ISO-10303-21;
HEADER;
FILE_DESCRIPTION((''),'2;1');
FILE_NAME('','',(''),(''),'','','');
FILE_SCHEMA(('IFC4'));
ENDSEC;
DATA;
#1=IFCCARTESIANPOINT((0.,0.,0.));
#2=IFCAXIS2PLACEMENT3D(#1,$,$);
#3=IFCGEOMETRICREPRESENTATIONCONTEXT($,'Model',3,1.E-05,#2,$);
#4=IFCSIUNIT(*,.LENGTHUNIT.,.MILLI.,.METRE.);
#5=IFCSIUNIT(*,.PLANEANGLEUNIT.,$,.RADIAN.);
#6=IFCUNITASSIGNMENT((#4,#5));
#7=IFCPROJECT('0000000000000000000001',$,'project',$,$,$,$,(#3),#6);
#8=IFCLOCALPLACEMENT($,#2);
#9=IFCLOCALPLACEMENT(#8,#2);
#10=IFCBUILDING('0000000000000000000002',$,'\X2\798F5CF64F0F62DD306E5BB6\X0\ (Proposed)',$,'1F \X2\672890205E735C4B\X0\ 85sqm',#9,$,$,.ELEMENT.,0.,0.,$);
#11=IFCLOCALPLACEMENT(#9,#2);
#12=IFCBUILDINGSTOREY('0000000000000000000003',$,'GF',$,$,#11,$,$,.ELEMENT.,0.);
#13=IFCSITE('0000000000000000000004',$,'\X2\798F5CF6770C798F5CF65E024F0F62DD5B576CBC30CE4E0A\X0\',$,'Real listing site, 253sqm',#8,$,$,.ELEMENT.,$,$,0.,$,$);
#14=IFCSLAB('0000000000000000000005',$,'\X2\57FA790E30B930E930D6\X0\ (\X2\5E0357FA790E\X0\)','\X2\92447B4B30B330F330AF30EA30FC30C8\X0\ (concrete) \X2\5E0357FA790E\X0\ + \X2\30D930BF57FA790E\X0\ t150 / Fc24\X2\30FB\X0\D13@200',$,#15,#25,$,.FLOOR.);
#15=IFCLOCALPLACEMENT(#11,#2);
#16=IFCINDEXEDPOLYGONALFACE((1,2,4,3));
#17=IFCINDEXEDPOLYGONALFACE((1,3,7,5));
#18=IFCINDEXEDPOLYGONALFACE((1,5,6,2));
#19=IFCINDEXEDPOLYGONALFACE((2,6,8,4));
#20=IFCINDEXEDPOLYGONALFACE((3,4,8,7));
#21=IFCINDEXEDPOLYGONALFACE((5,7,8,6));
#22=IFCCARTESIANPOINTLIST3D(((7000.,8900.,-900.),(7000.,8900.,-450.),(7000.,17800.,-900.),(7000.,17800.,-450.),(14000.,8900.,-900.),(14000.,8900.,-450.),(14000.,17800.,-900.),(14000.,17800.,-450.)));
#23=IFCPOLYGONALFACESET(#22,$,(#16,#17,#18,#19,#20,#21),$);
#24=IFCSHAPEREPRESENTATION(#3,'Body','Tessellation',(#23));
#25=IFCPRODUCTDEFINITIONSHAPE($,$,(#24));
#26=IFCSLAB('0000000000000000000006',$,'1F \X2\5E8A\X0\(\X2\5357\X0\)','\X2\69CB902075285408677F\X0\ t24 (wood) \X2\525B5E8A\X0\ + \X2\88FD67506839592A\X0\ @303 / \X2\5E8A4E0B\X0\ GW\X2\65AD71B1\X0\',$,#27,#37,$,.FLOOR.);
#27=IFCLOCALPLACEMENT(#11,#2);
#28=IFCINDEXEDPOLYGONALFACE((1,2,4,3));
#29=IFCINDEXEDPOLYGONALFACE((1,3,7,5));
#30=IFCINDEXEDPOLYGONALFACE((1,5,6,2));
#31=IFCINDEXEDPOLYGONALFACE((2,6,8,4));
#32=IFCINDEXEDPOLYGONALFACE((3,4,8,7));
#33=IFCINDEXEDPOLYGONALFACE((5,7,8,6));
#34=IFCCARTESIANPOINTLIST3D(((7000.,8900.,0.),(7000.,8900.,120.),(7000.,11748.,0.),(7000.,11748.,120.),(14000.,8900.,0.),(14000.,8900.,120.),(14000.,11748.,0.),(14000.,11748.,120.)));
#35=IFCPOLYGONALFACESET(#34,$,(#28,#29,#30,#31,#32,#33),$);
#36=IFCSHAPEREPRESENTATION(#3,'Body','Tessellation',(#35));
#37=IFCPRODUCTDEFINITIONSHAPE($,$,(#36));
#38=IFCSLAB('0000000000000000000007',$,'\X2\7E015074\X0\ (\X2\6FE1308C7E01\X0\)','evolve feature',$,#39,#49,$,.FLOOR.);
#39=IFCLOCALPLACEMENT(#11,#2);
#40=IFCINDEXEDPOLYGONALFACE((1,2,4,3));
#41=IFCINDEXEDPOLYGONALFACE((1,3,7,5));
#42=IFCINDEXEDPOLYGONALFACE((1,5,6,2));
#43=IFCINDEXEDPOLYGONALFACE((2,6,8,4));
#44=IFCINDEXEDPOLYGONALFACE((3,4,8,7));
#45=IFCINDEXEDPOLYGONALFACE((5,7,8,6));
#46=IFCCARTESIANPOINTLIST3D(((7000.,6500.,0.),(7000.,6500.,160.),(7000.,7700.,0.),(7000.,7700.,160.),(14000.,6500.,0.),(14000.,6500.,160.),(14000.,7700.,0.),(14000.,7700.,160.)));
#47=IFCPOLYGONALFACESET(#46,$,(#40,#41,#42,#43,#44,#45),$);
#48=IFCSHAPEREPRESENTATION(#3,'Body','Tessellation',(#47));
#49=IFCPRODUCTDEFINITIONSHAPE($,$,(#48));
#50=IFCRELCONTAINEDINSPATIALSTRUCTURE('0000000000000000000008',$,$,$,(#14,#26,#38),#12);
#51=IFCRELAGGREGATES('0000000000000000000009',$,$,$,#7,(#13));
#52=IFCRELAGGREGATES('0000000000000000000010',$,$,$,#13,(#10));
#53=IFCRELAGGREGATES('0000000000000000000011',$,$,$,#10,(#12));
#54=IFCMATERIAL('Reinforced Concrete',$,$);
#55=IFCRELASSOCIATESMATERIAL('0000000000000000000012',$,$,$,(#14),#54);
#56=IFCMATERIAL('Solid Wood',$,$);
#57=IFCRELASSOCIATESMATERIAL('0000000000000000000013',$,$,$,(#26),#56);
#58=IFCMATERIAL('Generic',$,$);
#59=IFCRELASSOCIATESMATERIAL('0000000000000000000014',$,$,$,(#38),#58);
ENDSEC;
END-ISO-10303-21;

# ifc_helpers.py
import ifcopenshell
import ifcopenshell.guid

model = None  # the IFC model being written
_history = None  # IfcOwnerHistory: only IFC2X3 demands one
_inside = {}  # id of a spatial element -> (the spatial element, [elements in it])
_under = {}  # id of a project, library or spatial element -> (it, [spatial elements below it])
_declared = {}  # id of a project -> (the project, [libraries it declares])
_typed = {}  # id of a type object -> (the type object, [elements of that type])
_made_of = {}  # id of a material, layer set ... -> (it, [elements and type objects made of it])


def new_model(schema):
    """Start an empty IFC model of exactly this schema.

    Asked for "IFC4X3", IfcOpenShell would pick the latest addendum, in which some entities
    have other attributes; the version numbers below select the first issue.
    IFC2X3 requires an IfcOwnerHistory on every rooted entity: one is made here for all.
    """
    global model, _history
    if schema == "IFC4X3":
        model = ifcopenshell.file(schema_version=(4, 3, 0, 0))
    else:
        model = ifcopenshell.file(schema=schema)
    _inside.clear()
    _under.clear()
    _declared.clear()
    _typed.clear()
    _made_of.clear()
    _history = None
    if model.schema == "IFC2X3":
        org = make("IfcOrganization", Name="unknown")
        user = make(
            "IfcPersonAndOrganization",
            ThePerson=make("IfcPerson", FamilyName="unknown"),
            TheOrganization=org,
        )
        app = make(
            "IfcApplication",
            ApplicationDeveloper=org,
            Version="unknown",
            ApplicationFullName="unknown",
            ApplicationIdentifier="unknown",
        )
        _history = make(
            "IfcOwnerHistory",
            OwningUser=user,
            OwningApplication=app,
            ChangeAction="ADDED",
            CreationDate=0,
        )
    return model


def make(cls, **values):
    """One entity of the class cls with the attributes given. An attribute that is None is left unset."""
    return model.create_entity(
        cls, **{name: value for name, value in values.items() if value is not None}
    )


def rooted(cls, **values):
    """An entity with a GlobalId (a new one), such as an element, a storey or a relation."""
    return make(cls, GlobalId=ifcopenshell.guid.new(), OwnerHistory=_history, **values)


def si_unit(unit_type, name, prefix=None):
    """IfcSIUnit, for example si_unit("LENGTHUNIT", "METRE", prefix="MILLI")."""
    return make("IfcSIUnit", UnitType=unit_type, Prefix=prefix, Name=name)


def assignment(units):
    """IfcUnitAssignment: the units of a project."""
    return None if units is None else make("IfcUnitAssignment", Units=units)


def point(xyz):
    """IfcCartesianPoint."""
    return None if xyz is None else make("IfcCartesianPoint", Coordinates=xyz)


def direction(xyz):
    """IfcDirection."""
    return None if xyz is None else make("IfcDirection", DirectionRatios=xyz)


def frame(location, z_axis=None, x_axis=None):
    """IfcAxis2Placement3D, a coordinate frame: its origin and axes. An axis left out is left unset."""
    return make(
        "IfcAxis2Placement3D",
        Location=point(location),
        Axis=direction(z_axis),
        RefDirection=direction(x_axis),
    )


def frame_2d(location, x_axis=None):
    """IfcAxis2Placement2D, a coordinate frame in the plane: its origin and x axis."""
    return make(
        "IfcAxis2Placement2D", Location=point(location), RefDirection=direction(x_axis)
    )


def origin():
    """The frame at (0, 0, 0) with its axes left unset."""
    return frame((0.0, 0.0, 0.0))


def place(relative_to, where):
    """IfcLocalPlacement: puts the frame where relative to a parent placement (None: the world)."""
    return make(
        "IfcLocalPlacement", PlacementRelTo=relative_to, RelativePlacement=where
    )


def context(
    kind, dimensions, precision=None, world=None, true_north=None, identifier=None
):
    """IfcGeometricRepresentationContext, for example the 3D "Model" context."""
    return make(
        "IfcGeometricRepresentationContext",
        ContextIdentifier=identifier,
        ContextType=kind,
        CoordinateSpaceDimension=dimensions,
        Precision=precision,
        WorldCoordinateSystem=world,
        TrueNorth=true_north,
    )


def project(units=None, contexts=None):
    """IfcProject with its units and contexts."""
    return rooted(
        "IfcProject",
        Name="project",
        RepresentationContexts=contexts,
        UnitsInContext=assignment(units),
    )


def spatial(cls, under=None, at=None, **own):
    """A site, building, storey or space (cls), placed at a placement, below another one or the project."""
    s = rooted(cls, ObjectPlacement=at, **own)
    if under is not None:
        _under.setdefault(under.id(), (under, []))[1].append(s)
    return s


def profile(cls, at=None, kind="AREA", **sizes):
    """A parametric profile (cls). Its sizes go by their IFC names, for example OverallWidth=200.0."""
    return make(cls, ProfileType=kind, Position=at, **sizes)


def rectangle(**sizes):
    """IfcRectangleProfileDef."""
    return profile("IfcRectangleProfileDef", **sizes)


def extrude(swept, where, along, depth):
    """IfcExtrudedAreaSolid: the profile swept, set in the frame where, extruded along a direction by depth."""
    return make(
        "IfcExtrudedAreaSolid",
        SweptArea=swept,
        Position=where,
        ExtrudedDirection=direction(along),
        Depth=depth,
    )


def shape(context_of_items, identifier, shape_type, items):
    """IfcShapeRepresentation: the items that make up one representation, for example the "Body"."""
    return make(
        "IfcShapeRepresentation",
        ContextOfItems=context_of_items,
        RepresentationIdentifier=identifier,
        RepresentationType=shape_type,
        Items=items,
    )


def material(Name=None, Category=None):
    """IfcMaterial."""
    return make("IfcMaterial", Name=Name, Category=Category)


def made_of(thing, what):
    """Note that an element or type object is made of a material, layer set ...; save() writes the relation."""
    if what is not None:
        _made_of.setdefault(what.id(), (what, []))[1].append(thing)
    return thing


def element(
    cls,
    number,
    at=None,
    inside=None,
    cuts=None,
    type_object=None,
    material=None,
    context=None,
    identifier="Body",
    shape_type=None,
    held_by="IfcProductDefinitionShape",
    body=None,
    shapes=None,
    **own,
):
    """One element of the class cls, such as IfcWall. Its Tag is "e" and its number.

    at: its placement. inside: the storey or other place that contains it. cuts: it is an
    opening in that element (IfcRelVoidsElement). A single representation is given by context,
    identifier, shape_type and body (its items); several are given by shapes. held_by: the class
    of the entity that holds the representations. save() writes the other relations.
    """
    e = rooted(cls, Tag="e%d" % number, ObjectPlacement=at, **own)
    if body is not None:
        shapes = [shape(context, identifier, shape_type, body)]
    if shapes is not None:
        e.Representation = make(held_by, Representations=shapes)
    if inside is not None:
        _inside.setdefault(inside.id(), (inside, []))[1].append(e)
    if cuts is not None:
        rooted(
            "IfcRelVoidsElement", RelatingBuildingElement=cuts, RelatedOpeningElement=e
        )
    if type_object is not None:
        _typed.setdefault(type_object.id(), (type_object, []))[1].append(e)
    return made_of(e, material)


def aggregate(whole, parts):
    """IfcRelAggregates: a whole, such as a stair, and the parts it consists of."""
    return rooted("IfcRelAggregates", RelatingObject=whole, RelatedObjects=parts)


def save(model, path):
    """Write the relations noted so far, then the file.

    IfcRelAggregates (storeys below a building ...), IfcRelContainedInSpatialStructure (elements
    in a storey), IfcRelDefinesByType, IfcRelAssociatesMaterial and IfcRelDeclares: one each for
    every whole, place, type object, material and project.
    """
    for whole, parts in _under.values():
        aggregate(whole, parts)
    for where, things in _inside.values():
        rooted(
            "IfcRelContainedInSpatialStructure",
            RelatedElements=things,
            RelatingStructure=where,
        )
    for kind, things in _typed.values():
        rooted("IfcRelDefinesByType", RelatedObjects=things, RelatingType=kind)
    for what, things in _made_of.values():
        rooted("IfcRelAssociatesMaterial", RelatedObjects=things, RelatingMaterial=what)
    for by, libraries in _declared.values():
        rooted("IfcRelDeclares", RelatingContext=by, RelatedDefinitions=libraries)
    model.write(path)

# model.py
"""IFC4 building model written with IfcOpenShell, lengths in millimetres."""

from ifc_helpers import new_model, si_unit, frame, frame_2d, origin, place, context, project, spatial, rectangle, extrude, material, element, save


model = new_model("IFC4")

# Units and contexts
model_context = context("Model", 3, precision=1e-05, world=origin())
ifc_project = project(units=[si_unit("LENGTHUNIT", "METRE", prefix="MILLI"), si_unit("PLANEANGLEUNIT", "RADIAN")], contexts=[model_context])

# Site, building, storey
site_placement = place(None, origin())
site = spatial("IfcSite", under=ifc_project, at=site_placement, Name="福島県福島市伏拝字沼ノ上", ObjectType="Real listing site, 253sqm", CompositionType="ELEMENT", RefElevation=0.0)
building_placement = place(site_placement, origin())
building = spatial("IfcBuilding", under=site, at=building_placement, Name="福島伏拝の家 (Proposed)", ObjectType="1F 木造平屋 85sqm", CompositionType="ELEMENT", ElevationOfRefHeight=0.0, ElevationOfTerrain=0.0)
storey_placement = place(building_placement, origin())
storey = spatial("IfcBuildingStorey", under=building, at=storey_placement, Name="GF", CompositionType="ELEMENT", Elevation=0.0)

# Slabs
ifc_material_1 = material(Name="Reinforced Concrete")
slab_1_placement = place(storey_placement, frame((3500.0, 4450.0, -450.0)))
element("IfcSlab", 1, at=slab_1_placement, inside=storey, material=ifc_material_1, Name="基礎スラブ (布基礎)", Description="鉄筋コンクリート (concrete) 布基礎 + ベタ基礎 t150 / Fc24・D13@200", PredefinedType="FLOOR", context=model_context, shape_type="SweptSolid", body=[
    extrude(rectangle(XDim=7000.0, YDim=8900.0, at=frame_2d((3500.0, 4450.0))), frame((3500.0, 4450.0, -450.0)), (0.0, 0.0, 1.0), 450.0),
])
ifc_material_2 = material(Name="Solid Wood")
slab_2_placement = place(storey_placement, frame((3500.0, 4450.0, 0.0)))
element("IfcSlab", 2, at=slab_2_placement, inside=storey, material=ifc_material_2, Name="1F 床(南)", Description="構造用合板 t24 (wood) 剛床 + 製材根太 @303 / 床下 GW断熱", PredefinedType="FLOOR", context=model_context, shape_type="SweptSolid", body=[
    extrude(rectangle(XDim=7000.0, YDim=2848.0, at=frame_2d((3500.0, 1424.0))), frame((3500.0, 4450.0, 0.0)), (0.0, 0.0, 1.0), 120.0),
])
ifc_material_3 = material(Name="Generic")
slab_3_placement = place(storey_placement, frame((3500.0, 3250.0, 0.0)))
element("IfcSlab", 3, at=slab_3_placement, inside=storey, material=ifc_material_3, Name="縁側 (濡れ縁)", Description="evolve feature", PredefinedType="FLOOR", context=model_context, shape_type="SweptSolid", body=[
    extrude(rectangle(XDim=7000.0, YDim=1200.0, at=frame_2d((3500.0, 600.0))), frame((3500.0, 3250.0, 0.0)), (0.0, 0.0, 1.0), 160.0),
])

save(model, "model.ifc")
